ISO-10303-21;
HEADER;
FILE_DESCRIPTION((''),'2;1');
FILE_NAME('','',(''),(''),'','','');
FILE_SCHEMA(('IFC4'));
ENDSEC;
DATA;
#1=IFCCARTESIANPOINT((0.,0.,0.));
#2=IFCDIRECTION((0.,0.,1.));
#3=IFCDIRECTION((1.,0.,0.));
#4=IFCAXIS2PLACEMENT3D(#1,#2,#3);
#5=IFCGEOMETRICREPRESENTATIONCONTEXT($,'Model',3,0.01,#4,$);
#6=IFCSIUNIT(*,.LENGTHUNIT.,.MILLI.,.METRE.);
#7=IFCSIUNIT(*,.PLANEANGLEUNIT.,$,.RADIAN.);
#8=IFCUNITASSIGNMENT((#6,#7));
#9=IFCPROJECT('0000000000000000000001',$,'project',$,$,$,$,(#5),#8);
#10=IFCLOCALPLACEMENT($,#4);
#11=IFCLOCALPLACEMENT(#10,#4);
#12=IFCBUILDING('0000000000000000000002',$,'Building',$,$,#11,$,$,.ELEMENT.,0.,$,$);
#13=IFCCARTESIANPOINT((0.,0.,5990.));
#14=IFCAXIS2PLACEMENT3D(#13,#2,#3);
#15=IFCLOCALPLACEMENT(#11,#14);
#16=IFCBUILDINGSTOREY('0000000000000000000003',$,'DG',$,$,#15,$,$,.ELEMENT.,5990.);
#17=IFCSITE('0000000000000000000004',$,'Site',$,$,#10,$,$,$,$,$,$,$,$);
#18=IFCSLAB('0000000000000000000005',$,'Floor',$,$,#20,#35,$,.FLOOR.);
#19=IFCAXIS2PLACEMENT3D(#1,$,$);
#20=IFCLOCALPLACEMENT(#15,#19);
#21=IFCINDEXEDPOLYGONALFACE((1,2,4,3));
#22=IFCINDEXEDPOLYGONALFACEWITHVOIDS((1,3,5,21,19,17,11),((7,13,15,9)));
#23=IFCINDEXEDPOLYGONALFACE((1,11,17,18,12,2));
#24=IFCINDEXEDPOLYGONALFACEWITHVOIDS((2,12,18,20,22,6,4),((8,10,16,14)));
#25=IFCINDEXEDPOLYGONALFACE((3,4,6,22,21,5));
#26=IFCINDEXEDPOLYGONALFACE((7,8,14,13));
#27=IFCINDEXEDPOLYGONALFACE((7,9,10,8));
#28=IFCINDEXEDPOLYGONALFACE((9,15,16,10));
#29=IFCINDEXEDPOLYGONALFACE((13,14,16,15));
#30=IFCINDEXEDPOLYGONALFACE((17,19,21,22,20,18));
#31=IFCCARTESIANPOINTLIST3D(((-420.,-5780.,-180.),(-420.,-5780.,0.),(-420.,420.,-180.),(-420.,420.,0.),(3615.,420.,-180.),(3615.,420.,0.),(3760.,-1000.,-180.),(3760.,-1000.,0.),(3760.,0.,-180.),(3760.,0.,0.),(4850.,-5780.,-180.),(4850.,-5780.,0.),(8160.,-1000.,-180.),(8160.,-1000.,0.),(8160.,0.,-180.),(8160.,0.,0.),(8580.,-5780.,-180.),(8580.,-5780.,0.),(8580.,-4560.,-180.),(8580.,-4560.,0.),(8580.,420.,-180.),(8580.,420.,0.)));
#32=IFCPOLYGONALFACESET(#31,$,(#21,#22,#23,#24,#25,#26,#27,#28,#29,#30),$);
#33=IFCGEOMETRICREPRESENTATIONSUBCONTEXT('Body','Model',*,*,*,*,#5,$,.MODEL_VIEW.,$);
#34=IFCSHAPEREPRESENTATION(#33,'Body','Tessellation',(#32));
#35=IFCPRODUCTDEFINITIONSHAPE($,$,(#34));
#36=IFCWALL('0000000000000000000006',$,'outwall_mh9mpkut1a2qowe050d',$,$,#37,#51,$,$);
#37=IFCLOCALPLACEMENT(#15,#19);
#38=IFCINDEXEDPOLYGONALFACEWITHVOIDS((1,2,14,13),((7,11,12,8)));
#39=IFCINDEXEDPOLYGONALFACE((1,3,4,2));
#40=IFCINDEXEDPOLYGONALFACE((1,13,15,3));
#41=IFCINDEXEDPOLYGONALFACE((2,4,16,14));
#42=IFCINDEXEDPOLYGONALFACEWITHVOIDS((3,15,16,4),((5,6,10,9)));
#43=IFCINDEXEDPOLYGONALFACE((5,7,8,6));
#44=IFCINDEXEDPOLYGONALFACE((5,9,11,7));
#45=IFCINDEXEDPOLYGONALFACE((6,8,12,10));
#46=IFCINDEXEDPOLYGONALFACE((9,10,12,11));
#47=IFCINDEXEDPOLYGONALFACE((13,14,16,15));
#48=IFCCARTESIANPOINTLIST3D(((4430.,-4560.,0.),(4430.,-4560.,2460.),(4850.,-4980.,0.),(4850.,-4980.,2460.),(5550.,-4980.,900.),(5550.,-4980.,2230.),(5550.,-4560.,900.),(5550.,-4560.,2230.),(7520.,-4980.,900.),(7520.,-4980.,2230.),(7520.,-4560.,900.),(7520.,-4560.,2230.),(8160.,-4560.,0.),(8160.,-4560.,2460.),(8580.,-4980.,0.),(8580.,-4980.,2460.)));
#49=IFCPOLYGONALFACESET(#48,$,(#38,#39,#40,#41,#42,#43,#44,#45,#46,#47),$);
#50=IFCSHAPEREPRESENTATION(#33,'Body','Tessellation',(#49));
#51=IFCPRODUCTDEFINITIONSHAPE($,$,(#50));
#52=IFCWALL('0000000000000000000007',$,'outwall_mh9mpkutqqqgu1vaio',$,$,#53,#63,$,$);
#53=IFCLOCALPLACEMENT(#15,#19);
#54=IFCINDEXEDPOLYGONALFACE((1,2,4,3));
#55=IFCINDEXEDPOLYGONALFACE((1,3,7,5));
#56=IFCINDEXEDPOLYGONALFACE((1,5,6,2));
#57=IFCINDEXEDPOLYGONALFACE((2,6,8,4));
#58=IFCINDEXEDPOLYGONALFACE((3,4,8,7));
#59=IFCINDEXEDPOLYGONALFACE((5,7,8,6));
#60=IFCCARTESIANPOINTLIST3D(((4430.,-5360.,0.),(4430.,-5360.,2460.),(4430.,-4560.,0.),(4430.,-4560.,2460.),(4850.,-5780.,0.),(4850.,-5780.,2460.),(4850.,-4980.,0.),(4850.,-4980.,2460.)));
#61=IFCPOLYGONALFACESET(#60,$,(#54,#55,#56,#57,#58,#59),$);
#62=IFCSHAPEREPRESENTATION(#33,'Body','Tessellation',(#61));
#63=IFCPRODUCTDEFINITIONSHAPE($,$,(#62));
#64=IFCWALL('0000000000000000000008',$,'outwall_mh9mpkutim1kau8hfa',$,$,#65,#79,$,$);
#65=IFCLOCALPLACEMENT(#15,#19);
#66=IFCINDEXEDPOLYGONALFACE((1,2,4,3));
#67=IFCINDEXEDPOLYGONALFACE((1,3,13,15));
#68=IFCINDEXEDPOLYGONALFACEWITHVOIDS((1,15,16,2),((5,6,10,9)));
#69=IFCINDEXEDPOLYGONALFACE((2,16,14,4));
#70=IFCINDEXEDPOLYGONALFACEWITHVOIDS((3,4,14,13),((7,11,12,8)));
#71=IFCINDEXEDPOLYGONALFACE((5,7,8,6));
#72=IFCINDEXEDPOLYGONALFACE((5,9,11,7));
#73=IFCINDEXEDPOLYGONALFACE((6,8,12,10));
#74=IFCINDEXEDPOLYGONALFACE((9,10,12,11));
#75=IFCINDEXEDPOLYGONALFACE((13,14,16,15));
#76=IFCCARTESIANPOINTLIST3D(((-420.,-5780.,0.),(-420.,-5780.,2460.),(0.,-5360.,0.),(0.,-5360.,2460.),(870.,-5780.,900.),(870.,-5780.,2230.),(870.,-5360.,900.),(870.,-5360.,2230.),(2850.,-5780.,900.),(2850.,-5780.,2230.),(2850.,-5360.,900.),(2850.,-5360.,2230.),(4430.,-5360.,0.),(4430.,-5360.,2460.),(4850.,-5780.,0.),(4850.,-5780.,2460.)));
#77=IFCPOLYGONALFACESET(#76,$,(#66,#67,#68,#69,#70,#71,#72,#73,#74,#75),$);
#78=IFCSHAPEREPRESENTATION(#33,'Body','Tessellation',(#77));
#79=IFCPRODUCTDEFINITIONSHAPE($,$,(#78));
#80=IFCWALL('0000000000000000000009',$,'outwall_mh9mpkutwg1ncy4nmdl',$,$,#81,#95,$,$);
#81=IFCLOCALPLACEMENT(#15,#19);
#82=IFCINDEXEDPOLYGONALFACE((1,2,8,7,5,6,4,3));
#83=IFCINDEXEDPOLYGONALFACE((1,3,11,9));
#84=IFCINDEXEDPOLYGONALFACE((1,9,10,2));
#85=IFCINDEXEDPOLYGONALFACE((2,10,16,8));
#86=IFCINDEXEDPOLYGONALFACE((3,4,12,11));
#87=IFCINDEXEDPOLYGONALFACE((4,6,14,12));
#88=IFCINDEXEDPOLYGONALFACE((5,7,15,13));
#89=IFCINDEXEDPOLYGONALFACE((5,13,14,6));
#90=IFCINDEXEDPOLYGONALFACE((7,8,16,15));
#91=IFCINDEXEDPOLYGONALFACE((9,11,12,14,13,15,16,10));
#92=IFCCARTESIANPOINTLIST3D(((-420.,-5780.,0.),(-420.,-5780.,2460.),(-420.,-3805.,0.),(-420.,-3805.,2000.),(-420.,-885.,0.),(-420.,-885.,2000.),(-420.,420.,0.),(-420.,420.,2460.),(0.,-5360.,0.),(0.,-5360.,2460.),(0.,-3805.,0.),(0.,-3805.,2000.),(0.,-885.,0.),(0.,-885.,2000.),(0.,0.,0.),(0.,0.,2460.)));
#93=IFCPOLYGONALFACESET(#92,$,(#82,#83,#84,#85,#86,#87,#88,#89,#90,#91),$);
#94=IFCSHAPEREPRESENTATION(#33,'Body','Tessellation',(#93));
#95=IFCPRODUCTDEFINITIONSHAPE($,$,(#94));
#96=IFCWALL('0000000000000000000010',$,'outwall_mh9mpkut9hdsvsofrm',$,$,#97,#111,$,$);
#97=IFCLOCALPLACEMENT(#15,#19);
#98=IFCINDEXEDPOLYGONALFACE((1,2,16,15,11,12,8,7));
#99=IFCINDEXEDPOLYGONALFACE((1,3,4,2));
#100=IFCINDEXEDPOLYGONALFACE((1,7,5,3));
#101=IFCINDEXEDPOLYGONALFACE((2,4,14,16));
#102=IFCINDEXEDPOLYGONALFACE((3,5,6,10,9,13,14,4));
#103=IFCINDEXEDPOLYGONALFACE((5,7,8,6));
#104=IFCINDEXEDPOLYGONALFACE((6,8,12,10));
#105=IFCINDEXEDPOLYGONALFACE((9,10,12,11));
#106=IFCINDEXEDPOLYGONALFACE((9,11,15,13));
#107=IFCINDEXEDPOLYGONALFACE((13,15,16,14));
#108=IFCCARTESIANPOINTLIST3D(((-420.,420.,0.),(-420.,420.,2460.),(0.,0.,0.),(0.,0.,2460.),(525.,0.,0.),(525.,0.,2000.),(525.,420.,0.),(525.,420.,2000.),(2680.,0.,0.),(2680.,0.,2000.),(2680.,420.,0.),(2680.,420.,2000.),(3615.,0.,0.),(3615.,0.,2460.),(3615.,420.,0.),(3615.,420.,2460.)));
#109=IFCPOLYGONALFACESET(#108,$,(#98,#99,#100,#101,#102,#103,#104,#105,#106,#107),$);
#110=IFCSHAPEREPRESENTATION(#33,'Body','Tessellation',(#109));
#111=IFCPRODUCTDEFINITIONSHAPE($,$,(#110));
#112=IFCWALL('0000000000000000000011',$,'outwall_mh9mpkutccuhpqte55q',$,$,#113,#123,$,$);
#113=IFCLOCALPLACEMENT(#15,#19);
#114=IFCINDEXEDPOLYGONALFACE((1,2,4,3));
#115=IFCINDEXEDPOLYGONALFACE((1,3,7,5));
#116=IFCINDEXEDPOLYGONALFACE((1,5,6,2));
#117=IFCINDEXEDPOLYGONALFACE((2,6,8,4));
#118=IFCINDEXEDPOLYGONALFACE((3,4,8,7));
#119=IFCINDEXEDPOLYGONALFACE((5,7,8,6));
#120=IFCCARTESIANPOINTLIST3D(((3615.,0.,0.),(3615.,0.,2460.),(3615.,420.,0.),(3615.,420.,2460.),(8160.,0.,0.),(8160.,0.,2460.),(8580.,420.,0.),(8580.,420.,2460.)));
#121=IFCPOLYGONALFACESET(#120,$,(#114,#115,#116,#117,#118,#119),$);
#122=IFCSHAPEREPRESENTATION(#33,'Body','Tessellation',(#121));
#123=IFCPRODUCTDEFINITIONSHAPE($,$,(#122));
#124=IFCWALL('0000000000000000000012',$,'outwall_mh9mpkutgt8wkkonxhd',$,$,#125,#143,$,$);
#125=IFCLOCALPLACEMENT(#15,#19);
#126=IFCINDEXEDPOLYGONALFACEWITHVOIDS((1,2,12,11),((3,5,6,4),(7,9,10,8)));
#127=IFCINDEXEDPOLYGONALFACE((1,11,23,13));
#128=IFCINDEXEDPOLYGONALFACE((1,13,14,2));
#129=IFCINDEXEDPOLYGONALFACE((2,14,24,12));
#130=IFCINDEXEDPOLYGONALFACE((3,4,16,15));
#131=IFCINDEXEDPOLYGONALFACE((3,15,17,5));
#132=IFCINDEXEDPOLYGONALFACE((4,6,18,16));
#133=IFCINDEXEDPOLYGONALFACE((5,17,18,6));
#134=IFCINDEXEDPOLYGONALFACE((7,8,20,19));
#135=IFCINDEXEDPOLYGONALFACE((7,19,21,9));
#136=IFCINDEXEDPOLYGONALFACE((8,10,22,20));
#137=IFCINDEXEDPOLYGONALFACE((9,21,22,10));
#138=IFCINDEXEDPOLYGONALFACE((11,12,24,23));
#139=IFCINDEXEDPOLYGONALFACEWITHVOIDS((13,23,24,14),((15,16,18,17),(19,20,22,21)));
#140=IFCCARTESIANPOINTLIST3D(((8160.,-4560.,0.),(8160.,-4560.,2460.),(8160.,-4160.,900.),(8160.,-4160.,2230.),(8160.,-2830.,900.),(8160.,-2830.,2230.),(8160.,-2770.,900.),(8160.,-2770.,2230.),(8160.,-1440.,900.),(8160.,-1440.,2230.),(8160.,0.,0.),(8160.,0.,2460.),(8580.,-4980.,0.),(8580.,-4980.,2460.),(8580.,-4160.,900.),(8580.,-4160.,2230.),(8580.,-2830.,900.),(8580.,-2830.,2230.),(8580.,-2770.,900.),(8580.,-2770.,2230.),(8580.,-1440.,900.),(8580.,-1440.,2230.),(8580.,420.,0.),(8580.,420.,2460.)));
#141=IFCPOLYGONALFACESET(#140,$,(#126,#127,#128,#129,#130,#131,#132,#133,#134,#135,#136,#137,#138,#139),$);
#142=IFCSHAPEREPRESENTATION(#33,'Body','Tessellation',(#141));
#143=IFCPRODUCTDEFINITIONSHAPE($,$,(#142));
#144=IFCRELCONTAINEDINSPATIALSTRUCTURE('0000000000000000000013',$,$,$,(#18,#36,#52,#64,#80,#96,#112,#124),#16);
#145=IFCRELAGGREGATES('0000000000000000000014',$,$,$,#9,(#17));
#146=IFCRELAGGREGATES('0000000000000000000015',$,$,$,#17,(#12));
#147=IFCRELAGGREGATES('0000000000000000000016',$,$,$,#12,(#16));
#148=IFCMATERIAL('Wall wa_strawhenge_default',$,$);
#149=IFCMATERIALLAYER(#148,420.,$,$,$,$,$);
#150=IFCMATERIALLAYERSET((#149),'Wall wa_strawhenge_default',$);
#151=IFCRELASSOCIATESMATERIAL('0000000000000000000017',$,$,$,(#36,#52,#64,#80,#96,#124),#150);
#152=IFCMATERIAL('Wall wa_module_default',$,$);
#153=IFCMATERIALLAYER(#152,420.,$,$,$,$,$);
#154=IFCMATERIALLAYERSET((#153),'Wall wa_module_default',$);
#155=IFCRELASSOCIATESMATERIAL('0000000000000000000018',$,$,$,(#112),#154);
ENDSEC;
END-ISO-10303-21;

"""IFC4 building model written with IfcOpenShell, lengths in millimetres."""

from ifc_helpers import new_model, si_unit, frame, origin_with_axes, place, context, subcontext, project, spatial, polyline, outline, extrude, material, layer, layer_set, layer_usage, element, save


model = new_model("IFC4")

# Units and contexts
model_context = context("Model", 3, precision=0.01, world=origin_with_axes())
body_context = subcontext(model_context, "Body", "Model", "MODEL_VIEW")
ifc_project = project(units=[si_unit("LENGTHUNIT", "METRE", prefix="MILLI"), si_unit("PLANEANGLEUNIT", "RADIAN")], contexts=[model_context])

# Site, building, storey
site_placement = place(None, origin_with_axes())
site = spatial("IfcSite", under=ifc_project, at=site_placement, Name="Site")
building_placement = place(site_placement, origin_with_axes())
building = spatial("IfcBuilding", under=site, at=building_placement, Name="Building", CompositionType="ELEMENT", ElevationOfRefHeight=0.0)
storey_placement = place(building_placement, frame((0.0, 0.0, 5990.0), z_axis=(0.0, 0.0, 1.0), x_axis=(1.0, 0.0, 0.0)))
storey = spatial("IfcBuildingStorey", under=building, at=storey_placement, Name="DG", CompositionType="ELEMENT", Elevation=5990.0)

# Slab
slab_placement = place(storey_placement, origin_with_axes())
element("IfcSlab", 1, at=slab_placement, inside=storey, Name="Floor", PredefinedType="FLOOR", context=body_context, shape_type="SweptSolid", body=[
    extrude(outline(polyline([(8580.0, -4560.0), (8580.0, 420.0), (3615.0, 420.0), (-420.0, 420.0), (-420.0, -5780.0), (4850.0, -5780.0), (8580.0, -5780.0), (8580.0, -4560.0)]), holes=[polyline([(3760.0, -1000.0), (3760.0, 0.0), (8160.0, 0.0), (8160.0, -1000.0), (3760.0, -1000.0)])]), origin_with_axes(), (0.0, 0.0, -1.0), 180.0),
])

# Wall, opening
ifc_material_1 = material(Name="Wall wa_strawhenge_default")
ifc_layer_1 = layer(ifc_material_1, 420.0)
ifc_layer_set_1 = layer_set([ifc_layer_1], Name="Wall wa_strawhenge_default")
ifc_layer_usage_1 = layer_usage(ifc_layer_set_1, "AXIS2", "POSITIVE", 0.0)
wall_1_placement = place(storey_placement, frame((8160.0, -4560.0, 0.0), z_axis=(0.0, 0.0, 1.0), x_axis=(-1.0, 0.0, 0.0)))
wall_1 = element("IfcWall", 2, at=wall_1_placement, inside=storey, material=ifc_layer_usage_1, Name="outwall_mh9mpkut1a2qowe050d", context=body_context, shape_type="SweptSolid", body=[
    extrude(outline(polyline([(0.0, 0.0), (3730.0, 0.0), (3310.0, 420.0), (-420.0, 420.0), (0.0, 0.0)])), origin_with_axes(), (0.0, 0.0, 1.0), 2460.0),
])
opening_1_placement = place(wall_1_placement, frame((640.0, 0.0, 900.0), z_axis=(0.0, 0.0, 1.0), x_axis=(1.0, 0.0, 0.0)))
element("IfcOpeningElement", 3, at=opening_1_placement, cuts=wall_1, context=body_context, shape_type="SweptSolid", body=[
    extrude(outline(polyline([(0.0, 0.0), (1970.0, 0.0), (1970.0, 420.0), (0.0, 420.0), (0.0, 0.0)])), origin_with_axes(), (0.0, 0.0, 1.0), 1330.0),
])

# Wall
wall_2_placement = place(storey_placement, frame((4430.0, -4560.0, 0.0), z_axis=(0.0, 0.0, 1.0), x_axis=(0.0, -1.0, 0.0)))
element("IfcWall", 4, at=wall_2_placement, inside=storey, material=ifc_layer_usage_1, Name="outwall_mh9mpkutqqqgu1vaio", context=body_context, shape_type="SweptSolid", body=[
    extrude(outline(polyline([(0.0, 0.0), (800.0, 0.0), (1220.0, 420.0), (420.0, 420.0), (0.0, 0.0)])), origin_with_axes(), (0.0, 0.0, 1.0), 2460.0),
])

# Walls, openings
wall_3_placement = place(storey_placement, frame((4430.0, -5360.0, 0.0), z_axis=(0.0, 0.0, 1.0), x_axis=(-1.0, 0.0, 0.0)))
wall_3 = element("IfcWall", 5, at=wall_3_placement, inside=storey, material=ifc_layer_usage_1, Name="outwall_mh9mpkutim1kau8hfa", context=body_context, shape_type="SweptSolid", body=[
    extrude(outline(polyline([(0.0, 0.0), (4430.0, 0.0), (4850.0, 420.0), (-420.0, 420.0), (0.0, 0.0)])), origin_with_axes(), (0.0, 0.0, 1.0), 2460.0),
])
opening_2_placement = place(wall_3_placement, frame((1580.0, 0.0, 900.0), z_axis=(0.0, 0.0, 1.0), x_axis=(1.0, 0.0, 0.0)))
element("IfcOpeningElement", 6, at=opening_2_placement, cuts=wall_3, context=body_context, shape_type="SweptSolid", body=[
    extrude(outline(polyline([(0.0, 0.0), (1980.0, 0.0), (1980.0, 420.0), (0.0, 420.0), (0.0, 0.0)])), origin_with_axes(), (0.0, 0.0, 1.0), 1330.0),
])
wall_4_placement = place(storey_placement, frame((0.0, -5360.0, 0.0), z_axis=(0.0, 0.0, 1.0), x_axis=(0.0, 1.0, 0.0)))
wall_4 = element("IfcWall", 7, at=wall_4_placement, inside=storey, material=ifc_layer_usage_1, Name="outwall_mh9mpkutwg1ncy4nmdl", context=body_context, shape_type="SweptSolid", body=[
    extrude(outline(polyline([(0.0, 0.0), (5360.0, 0.0), (5780.0, 420.0), (-420.0, 420.0), (0.0, 0.0)])), origin_with_axes(), (0.0, 0.0, 1.0), 2460.0),
])
opening_3_placement = place(wall_4_placement, frame((1555.0, 0.0, 0.0), z_axis=(0.0, 0.0, 1.0), x_axis=(1.0, 0.0, 0.0)))
element("IfcOpeningElement", 8, at=opening_3_placement, cuts=wall_4, context=body_context, shape_type="SweptSolid", body=[
    extrude(outline(polyline([(0.0, 0.0), (2920.0, 0.0), (2920.0, 420.0), (0.0, 420.0), (0.0, 0.0)])), origin_with_axes(), (0.0, 0.0, 1.0), 2000.0),
])
wall_5_placement = place(storey_placement, frame((0.0, 0.0, 0.0), z_axis=(0.0, 0.0, 1.0), x_axis=(1.0, 0.0, 0.0)))
wall_5 = element("IfcWall", 9, at=wall_5_placement, inside=storey, material=ifc_layer_usage_1, Name="outwall_mh9mpkut9hdsvsofrm", context=body_context, shape_type="SweptSolid", body=[
    extrude(outline(polyline([(0.0, 0.0), (3615.0, 0.0), (3615.0, 420.0), (-420.0, 420.0), (0.0, 0.0)])), origin_with_axes(), (0.0, 0.0, 1.0), 2460.0),
])
opening_4_placement = place(wall_5_placement, frame((525.0, 0.0, 0.0), z_axis=(0.0, 0.0, 1.0), x_axis=(1.0, 0.0, 0.0)))
element("IfcOpeningElement", 10, at=opening_4_placement, cuts=wall_5, context=body_context, shape_type="SweptSolid", body=[
    extrude(outline(polyline([(0.0, 0.0), (2155.0, 0.0), (2155.0, 420.0), (0.0, 420.0), (0.0, 0.0)])), origin_with_axes(), (0.0, 0.0, 1.0), 2000.0),
])

# Wall
ifc_material_2 = material(Name="Wall wa_module_default")
ifc_layer_2 = layer(ifc_material_2, 420.0)
ifc_layer_set_2 = layer_set([ifc_layer_2], Name="Wall wa_module_default")
ifc_layer_usage_2 = layer_usage(ifc_layer_set_2, "AXIS2", "POSITIVE", 0.0)
wall_6_placement = place(storey_placement, frame((3615.0, 0.0, 0.0), z_axis=(0.0, 0.0, 1.0), x_axis=(1.0, 0.0, 0.0)))
element("IfcWall", 11, at=wall_6_placement, inside=storey, material=ifc_layer_usage_2, Name="outwall_mh9mpkutccuhpqte55q", context=body_context, shape_type="SweptSolid", body=[
    extrude(outline(polyline([(0.0, 0.0), (4545.0, 0.0), (4965.0, 420.0), (0.0, 420.0), (0.0, 0.0)])), origin_with_axes(), (0.0, 0.0, 1.0), 2460.0),
])

# Wall, openings
wall_7_placement = place(storey_placement, frame((8160.0, 0.0, 0.0), z_axis=(0.0, 0.0, 1.0), x_axis=(0.0, -1.0, 0.0)))
wall_7 = element("IfcWall", 12, at=wall_7_placement, inside=storey, material=ifc_layer_usage_1, Name="outwall_mh9mpkutgt8wkkonxhd", context=body_context, shape_type="SweptSolid", body=[
    extrude(outline(polyline([(0.0, 0.0), (4560.0, 0.0), (4980.0, 420.0), (-420.0, 420.0), (0.0, 0.0)])), origin_with_axes(), (0.0, 0.0, 1.0), 2460.0),
])
opening_5_placement = place(wall_7_placement, frame((2830.0, 0.0, 900.0), z_axis=(0.0, 0.0, 1.0), x_axis=(1.0, 0.0, 0.0)))
element("IfcOpeningElement", 13, at=opening_5_placement, cuts=wall_7, context=body_context, shape_type="SweptSolid", body=[
    extrude(outline(polyline([(0.0, 0.0), (1330.0, 0.0), (1330.0, 420.0), (0.0, 420.0), (0.0, 0.0)])), origin_with_axes(), (0.0, 0.0, 1.0), 1330.0),
])
opening_6_placement = place(wall_7_placement, frame((1440.0, 0.0, 900.0), z_axis=(0.0, 0.0, 1.0), x_axis=(1.0, 0.0, 0.0)))
element("IfcOpeningElement", 14, at=opening_6_placement, cuts=wall_7, context=body_context, shape_type="SweptSolid", body=[
    extrude(outline(polyline([(0.0, 0.0), (1330.0, 0.0), (1330.0, 420.0), (0.0, 420.0), (0.0, 0.0)])), origin_with_axes(), (0.0, 0.0, 1.0), 1330.0),
])

save(model, "model.ifc")
